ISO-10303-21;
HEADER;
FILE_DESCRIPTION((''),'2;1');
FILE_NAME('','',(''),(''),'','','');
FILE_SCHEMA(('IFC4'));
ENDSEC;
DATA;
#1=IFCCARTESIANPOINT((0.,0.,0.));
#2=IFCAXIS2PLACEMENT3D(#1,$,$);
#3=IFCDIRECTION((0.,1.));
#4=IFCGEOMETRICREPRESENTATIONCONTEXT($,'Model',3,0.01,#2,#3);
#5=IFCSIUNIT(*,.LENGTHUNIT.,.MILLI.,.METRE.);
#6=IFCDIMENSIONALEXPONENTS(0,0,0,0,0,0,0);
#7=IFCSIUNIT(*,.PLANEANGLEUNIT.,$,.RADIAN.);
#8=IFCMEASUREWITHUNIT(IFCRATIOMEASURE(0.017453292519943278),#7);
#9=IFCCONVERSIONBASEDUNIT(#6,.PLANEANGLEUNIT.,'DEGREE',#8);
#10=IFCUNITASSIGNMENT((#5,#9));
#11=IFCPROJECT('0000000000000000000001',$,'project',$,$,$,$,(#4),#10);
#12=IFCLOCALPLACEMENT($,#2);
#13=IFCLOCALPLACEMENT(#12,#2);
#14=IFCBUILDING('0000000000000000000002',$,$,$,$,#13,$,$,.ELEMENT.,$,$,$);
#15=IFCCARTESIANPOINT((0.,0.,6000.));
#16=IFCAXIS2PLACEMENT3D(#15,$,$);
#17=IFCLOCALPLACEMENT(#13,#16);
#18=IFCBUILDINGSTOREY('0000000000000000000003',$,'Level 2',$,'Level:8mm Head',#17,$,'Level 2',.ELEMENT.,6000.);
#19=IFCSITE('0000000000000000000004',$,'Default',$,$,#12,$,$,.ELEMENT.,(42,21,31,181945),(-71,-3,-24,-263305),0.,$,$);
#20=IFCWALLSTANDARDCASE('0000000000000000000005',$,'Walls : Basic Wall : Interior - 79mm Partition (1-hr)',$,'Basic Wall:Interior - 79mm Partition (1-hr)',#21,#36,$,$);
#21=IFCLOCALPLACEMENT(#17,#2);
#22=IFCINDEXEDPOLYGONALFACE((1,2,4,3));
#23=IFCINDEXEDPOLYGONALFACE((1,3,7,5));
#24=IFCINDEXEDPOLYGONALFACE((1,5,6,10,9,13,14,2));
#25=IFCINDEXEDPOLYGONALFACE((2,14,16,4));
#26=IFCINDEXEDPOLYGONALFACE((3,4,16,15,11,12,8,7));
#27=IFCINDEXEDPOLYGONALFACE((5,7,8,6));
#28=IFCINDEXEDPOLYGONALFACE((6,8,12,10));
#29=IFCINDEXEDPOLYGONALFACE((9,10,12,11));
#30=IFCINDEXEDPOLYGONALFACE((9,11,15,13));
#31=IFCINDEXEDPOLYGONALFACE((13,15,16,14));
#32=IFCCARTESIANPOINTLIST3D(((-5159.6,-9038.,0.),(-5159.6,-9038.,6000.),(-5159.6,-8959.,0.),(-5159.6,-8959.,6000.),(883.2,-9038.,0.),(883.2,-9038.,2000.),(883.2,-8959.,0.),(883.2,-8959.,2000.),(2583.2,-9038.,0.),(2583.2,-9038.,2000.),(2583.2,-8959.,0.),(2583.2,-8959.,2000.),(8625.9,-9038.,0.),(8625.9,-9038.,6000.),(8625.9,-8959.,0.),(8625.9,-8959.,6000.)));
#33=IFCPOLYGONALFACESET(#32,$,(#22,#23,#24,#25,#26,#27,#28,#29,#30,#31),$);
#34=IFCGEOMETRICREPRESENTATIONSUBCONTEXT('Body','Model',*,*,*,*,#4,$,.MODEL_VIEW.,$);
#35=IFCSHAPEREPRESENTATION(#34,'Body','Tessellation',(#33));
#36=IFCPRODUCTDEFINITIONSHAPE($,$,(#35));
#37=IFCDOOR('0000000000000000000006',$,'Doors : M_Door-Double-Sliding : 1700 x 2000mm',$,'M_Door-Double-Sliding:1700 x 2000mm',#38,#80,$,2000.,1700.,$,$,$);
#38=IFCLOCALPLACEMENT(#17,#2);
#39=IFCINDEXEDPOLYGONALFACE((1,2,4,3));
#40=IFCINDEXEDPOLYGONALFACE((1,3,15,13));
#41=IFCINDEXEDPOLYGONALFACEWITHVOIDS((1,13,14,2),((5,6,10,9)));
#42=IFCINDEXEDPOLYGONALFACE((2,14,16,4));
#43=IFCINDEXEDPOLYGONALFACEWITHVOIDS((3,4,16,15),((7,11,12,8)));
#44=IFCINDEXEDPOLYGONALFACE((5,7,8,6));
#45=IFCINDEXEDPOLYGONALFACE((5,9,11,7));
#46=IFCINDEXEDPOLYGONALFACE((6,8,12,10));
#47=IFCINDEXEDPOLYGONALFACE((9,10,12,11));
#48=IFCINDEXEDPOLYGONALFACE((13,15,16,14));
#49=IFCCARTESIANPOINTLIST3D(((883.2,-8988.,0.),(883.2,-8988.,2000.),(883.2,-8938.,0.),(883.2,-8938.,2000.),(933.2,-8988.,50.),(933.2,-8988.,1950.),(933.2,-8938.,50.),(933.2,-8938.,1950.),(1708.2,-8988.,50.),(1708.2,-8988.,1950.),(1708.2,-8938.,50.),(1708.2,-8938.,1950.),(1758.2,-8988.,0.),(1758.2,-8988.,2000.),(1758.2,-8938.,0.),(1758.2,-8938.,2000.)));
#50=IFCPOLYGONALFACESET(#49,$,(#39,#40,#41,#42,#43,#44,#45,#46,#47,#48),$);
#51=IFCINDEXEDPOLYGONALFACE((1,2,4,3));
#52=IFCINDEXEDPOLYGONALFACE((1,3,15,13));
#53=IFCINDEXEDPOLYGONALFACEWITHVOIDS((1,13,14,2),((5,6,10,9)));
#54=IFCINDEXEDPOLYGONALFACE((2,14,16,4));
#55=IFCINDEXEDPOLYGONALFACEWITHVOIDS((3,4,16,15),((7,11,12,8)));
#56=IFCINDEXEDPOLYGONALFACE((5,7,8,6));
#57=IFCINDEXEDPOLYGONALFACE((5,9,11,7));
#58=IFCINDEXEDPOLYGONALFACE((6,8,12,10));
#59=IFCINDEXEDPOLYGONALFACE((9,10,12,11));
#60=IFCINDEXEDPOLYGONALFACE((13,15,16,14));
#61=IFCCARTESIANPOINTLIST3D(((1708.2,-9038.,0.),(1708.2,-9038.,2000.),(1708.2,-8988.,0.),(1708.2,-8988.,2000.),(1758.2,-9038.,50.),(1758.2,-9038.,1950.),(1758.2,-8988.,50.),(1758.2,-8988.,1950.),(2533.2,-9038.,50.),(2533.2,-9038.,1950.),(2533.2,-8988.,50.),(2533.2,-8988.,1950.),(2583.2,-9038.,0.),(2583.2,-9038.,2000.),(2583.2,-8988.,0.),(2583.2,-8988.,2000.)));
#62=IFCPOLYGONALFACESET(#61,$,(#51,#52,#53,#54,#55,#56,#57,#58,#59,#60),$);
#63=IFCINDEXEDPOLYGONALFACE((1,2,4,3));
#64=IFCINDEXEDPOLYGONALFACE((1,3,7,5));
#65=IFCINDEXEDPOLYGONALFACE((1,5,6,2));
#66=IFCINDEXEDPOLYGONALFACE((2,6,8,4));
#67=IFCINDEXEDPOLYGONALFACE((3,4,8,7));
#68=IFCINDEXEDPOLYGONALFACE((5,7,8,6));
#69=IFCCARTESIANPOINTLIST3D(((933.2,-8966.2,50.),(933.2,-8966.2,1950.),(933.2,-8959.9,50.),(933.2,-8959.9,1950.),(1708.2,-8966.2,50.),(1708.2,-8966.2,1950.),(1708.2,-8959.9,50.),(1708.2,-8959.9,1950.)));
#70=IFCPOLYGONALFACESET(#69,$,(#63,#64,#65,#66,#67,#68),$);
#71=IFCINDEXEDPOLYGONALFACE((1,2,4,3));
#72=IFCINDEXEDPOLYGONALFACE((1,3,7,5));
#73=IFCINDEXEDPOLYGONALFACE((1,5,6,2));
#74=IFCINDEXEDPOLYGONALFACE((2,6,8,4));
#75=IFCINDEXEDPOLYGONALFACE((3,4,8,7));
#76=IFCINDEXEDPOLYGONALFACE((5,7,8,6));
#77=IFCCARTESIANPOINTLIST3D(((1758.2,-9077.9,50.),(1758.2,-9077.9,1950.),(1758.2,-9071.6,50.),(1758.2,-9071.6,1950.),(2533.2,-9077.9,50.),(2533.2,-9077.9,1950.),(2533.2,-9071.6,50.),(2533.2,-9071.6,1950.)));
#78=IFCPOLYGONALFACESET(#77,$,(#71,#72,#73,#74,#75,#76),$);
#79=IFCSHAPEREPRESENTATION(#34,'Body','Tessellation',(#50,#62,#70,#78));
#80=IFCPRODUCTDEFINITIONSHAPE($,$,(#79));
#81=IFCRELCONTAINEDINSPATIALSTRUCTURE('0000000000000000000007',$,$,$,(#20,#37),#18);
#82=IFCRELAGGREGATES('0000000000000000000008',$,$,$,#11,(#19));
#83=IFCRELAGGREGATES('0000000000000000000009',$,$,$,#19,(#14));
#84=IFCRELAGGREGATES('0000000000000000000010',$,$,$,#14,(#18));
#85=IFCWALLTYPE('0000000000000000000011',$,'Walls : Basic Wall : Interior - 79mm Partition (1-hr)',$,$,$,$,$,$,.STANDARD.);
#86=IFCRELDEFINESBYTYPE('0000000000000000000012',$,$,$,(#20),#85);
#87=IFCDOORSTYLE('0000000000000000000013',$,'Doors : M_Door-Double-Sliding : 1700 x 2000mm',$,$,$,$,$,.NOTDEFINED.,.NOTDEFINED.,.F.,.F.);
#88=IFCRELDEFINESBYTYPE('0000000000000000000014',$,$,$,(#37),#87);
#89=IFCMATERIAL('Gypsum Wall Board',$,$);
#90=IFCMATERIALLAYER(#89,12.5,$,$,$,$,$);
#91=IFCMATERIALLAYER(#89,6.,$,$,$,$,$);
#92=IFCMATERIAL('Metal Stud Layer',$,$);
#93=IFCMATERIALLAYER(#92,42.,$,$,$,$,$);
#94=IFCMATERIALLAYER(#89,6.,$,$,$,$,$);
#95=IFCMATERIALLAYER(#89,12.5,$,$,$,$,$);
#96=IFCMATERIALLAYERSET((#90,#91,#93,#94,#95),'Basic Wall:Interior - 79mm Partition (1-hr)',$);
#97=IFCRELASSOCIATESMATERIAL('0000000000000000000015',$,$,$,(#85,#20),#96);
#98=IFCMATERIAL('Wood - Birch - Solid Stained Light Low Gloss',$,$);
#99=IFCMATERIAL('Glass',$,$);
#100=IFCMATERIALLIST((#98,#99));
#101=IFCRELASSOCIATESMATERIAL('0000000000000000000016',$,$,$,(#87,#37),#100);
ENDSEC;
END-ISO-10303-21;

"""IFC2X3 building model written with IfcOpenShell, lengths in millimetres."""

from ifc_helpers import new_model, entity, si_unit, converted_unit, direction, frame, frame_2d, origin, origin_2d_with_axis, place, context, subcontext, project, spatial, polyline, rectangle, outline, extrude, source, transform, mapped, material, material_list, layer, layer_set, layer_usage, type_object, type_shapes, element, fill, save


model = new_model("IFC2X3")

# Units and contexts
model_context = context("Model", 3, precision=0.01, world=origin(), true_north=direction((0.0, 1.0)))
body_context = subcontext(model_context, "Body", "Model", "MODEL_VIEW")
ifc_project = project(units=[si_unit("LENGTHUNIT", "METRE", prefix="MILLI"), converted_unit("PLANEANGLEUNIT", "DEGREE", entity("IfcRatioMeasure", 0.017453292519943278), si_unit("PLANEANGLEUNIT", "RADIAN"), dimensions=[0, 0, 0, 0, 0, 0, 0])], contexts=[model_context])

# Site, building, storey
site_placement = place(None, origin())
site = spatial("IfcSite", under=ifc_project, at=site_placement, Name="Default", CompositionType="ELEMENT", RefLatitude=(42, 21, 31, 181945), RefLongitude=(-71, -3, -24, -263305), RefElevation=0.0)
building_placement = place(site_placement, origin())
building = spatial("IfcBuilding", under=site, at=building_placement, CompositionType="ELEMENT")
storey_placement = place(building_placement, frame((0.0, 0.0, 6000.0)))
storey = spatial("IfcBuildingStorey", under=building, at=storey_placement, Name="Level 2", ObjectType="Level:8mm Head", LongName="Level 2", CompositionType="ELEMENT", Elevation=6000.0)

# Shared definitions
ifc_material_1 = material(Name="Metal Stud Layer")
ifc_material_2 = material(Name="Gypsum Wall Board")
ifc_layer_1 = layer(ifc_material_2, 12.5)
ifc_layer_2 = layer(ifc_material_2, 6.0)
ifc_layer_3 = layer(ifc_material_1, 42.0)
ifc_layer_4 = layer(ifc_material_2, 6.0)
ifc_layer_5 = layer(ifc_material_2, 12.5)
ifc_layer_set_1 = layer_set([ifc_layer_1, ifc_layer_2, ifc_layer_3, ifc_layer_4, ifc_layer_5], Name="Basic Wall:Interior - 79mm Partition (1-hr)")
ifc_layer_usage_1 = layer_usage(ifc_layer_set_1, "AXIS2", "NEGATIVE", 39.5)
wall_type_1 = type_object("IfcWallType", Name="Walls : Basic Wall : Interior - 79mm Partition (1-hr)", PredefinedType="STANDARD", material=ifc_layer_set_1)

# Wall, opening, door
ifc_material_3 = material(Name="Wood - Birch - Solid Stained Light Low Gloss")
ifc_material_4 = material(Name="Glass")
ifc_material_list = material_list([ifc_material_3, ifc_material_4])
door_style = type_object("IfcDoorStyle", Name="Doors : M_Door-Double-Sliding : 1700 x 2000mm", ConstructionType="NOTDEFINED", OperationType="NOTDEFINED", ParameterTakesPrecedence=False, Sizeable=False, material=ifc_material_list)
shared_shape = source(origin(), body_context, "Body", "SweptSolid", [
    extrude(outline(polyline([(-437.5, -1000.0), (437.5, -1000.0), (437.5, 1000.0), (-437.5, 1000.0), (-437.5, -1000.0)]), holes=[polyline([(-387.5, -950.0), (-387.5, 950.0), (387.5, 950.0), (387.5, -950.0), (-387.5, -950.0)])]), frame((1262.5, -21.0, 1000.0), z_axis=(0.0, 1.0, 0.0), x_axis=(1.0, 0.0, 0.0)), (0.0, 0.0, 1.0), 50.0),
    extrude(outline(polyline([(-1000.0, -437.5), (1000.0, -437.5), (1000.0, 437.5), (-1000.0, 437.5), (-1000.0, -437.5)]), holes=[polyline([(-950.0, -387.5), (-950.0, 387.5), (950.0, 387.5), (950.0, -387.5), (-950.0, -387.5)])]), frame((437.5, 29.0, 1000.0), z_axis=(0.0, 1.0, 0.0), x_axis=(0.0, 0.0, -1.0)), (0.0, 0.0, 1.0), 50.0),
    extrude(rectangle(XDim=6.3, YDim=775.0, at=frame_2d((0.0, 0.0), x_axis=(1.0, 0.0))), frame((1262.5, 4.0, 50.0), z_axis=(0.0, 0.0, 1.0), x_axis=(0.0, -1.0, 0.0)), (0.0, 0.0, 1.0), 1900.0),
    extrude(rectangle(XDim=6.4, YDim=775.0, at=origin_2d_with_axis()), frame((437.5, 115.7, 50.0), z_axis=(0.0, 0.0, 1.0), x_axis=(0.0, 1.0, 0.0)), (0.0, 0.0, 1.0), 1900.0),
])
type_shapes(door_style, [shared_shape])
wall_1_placement = place(storey_placement, frame((-5159.6, -8998.5, 0.0)))
wall_1 = element("IfcWallStandardCase", 1, at=wall_1_placement, inside=storey, type_object=wall_type_1, material=ifc_layer_usage_1, Name="Walls : Basic Wall : Interior - 79mm Partition (1-hr)", ObjectType="Basic Wall:Interior - 79mm Partition (1-hr)", context=body_context, shape_type="SweptSolid", body=[
    extrude(rectangle(XDim=13785.5, YDim=79.0, at=frame_2d((6892.8, 0.0), x_axis=(1.0, 0.0))), origin(), (0.0, 0.0, 1.0), 6000.0),
])
opening_1_placement = place(wall_1_placement, frame((7742.8, 39.5, 0.0)))
opening_1 = element("IfcOpeningElement", 2, at=opening_1_placement, cuts=wall_1, ObjectType="Opening", context=body_context, shape_type="SweptSolid", body=[
    extrude(rectangle(XDim=2000.0, YDim=1700.0, at=frame_2d((1000.0, 850.0), x_axis=(-1.0, 0.0))), frame((0.0, 0.0, 0.0), z_axis=(0.0, -1.0, 0.0), x_axis=(0.0, 0.0, 1.0)), (0.0, 0.0, 1.0), 79.0),
])
door_1_placement = place(opening_1_placement, frame((0.0, 0.0, 0.0), z_axis=(0.0, 0.0, 1.0), x_axis=(-1.0, 0.0, 0.0)))
door_1 = element("IfcDoor", 3, at=door_1_placement, inside=storey, type_object=door_style, material=ifc_material_list, Name="Doors : M_Door-Double-Sliding : 1700 x 2000mm", ObjectType="M_Door-Double-Sliding:1700 x 2000mm", OverallHeight=2000.0, OverallWidth=1700.0, context=body_context, shape_type="MappedRepresentation", body=[
    mapped(shared_shape, transform((0.0, 0.0, 0.0), scale=1.0)),
])
fill(opening_1, door_1)

save(model, "model.ifc")
